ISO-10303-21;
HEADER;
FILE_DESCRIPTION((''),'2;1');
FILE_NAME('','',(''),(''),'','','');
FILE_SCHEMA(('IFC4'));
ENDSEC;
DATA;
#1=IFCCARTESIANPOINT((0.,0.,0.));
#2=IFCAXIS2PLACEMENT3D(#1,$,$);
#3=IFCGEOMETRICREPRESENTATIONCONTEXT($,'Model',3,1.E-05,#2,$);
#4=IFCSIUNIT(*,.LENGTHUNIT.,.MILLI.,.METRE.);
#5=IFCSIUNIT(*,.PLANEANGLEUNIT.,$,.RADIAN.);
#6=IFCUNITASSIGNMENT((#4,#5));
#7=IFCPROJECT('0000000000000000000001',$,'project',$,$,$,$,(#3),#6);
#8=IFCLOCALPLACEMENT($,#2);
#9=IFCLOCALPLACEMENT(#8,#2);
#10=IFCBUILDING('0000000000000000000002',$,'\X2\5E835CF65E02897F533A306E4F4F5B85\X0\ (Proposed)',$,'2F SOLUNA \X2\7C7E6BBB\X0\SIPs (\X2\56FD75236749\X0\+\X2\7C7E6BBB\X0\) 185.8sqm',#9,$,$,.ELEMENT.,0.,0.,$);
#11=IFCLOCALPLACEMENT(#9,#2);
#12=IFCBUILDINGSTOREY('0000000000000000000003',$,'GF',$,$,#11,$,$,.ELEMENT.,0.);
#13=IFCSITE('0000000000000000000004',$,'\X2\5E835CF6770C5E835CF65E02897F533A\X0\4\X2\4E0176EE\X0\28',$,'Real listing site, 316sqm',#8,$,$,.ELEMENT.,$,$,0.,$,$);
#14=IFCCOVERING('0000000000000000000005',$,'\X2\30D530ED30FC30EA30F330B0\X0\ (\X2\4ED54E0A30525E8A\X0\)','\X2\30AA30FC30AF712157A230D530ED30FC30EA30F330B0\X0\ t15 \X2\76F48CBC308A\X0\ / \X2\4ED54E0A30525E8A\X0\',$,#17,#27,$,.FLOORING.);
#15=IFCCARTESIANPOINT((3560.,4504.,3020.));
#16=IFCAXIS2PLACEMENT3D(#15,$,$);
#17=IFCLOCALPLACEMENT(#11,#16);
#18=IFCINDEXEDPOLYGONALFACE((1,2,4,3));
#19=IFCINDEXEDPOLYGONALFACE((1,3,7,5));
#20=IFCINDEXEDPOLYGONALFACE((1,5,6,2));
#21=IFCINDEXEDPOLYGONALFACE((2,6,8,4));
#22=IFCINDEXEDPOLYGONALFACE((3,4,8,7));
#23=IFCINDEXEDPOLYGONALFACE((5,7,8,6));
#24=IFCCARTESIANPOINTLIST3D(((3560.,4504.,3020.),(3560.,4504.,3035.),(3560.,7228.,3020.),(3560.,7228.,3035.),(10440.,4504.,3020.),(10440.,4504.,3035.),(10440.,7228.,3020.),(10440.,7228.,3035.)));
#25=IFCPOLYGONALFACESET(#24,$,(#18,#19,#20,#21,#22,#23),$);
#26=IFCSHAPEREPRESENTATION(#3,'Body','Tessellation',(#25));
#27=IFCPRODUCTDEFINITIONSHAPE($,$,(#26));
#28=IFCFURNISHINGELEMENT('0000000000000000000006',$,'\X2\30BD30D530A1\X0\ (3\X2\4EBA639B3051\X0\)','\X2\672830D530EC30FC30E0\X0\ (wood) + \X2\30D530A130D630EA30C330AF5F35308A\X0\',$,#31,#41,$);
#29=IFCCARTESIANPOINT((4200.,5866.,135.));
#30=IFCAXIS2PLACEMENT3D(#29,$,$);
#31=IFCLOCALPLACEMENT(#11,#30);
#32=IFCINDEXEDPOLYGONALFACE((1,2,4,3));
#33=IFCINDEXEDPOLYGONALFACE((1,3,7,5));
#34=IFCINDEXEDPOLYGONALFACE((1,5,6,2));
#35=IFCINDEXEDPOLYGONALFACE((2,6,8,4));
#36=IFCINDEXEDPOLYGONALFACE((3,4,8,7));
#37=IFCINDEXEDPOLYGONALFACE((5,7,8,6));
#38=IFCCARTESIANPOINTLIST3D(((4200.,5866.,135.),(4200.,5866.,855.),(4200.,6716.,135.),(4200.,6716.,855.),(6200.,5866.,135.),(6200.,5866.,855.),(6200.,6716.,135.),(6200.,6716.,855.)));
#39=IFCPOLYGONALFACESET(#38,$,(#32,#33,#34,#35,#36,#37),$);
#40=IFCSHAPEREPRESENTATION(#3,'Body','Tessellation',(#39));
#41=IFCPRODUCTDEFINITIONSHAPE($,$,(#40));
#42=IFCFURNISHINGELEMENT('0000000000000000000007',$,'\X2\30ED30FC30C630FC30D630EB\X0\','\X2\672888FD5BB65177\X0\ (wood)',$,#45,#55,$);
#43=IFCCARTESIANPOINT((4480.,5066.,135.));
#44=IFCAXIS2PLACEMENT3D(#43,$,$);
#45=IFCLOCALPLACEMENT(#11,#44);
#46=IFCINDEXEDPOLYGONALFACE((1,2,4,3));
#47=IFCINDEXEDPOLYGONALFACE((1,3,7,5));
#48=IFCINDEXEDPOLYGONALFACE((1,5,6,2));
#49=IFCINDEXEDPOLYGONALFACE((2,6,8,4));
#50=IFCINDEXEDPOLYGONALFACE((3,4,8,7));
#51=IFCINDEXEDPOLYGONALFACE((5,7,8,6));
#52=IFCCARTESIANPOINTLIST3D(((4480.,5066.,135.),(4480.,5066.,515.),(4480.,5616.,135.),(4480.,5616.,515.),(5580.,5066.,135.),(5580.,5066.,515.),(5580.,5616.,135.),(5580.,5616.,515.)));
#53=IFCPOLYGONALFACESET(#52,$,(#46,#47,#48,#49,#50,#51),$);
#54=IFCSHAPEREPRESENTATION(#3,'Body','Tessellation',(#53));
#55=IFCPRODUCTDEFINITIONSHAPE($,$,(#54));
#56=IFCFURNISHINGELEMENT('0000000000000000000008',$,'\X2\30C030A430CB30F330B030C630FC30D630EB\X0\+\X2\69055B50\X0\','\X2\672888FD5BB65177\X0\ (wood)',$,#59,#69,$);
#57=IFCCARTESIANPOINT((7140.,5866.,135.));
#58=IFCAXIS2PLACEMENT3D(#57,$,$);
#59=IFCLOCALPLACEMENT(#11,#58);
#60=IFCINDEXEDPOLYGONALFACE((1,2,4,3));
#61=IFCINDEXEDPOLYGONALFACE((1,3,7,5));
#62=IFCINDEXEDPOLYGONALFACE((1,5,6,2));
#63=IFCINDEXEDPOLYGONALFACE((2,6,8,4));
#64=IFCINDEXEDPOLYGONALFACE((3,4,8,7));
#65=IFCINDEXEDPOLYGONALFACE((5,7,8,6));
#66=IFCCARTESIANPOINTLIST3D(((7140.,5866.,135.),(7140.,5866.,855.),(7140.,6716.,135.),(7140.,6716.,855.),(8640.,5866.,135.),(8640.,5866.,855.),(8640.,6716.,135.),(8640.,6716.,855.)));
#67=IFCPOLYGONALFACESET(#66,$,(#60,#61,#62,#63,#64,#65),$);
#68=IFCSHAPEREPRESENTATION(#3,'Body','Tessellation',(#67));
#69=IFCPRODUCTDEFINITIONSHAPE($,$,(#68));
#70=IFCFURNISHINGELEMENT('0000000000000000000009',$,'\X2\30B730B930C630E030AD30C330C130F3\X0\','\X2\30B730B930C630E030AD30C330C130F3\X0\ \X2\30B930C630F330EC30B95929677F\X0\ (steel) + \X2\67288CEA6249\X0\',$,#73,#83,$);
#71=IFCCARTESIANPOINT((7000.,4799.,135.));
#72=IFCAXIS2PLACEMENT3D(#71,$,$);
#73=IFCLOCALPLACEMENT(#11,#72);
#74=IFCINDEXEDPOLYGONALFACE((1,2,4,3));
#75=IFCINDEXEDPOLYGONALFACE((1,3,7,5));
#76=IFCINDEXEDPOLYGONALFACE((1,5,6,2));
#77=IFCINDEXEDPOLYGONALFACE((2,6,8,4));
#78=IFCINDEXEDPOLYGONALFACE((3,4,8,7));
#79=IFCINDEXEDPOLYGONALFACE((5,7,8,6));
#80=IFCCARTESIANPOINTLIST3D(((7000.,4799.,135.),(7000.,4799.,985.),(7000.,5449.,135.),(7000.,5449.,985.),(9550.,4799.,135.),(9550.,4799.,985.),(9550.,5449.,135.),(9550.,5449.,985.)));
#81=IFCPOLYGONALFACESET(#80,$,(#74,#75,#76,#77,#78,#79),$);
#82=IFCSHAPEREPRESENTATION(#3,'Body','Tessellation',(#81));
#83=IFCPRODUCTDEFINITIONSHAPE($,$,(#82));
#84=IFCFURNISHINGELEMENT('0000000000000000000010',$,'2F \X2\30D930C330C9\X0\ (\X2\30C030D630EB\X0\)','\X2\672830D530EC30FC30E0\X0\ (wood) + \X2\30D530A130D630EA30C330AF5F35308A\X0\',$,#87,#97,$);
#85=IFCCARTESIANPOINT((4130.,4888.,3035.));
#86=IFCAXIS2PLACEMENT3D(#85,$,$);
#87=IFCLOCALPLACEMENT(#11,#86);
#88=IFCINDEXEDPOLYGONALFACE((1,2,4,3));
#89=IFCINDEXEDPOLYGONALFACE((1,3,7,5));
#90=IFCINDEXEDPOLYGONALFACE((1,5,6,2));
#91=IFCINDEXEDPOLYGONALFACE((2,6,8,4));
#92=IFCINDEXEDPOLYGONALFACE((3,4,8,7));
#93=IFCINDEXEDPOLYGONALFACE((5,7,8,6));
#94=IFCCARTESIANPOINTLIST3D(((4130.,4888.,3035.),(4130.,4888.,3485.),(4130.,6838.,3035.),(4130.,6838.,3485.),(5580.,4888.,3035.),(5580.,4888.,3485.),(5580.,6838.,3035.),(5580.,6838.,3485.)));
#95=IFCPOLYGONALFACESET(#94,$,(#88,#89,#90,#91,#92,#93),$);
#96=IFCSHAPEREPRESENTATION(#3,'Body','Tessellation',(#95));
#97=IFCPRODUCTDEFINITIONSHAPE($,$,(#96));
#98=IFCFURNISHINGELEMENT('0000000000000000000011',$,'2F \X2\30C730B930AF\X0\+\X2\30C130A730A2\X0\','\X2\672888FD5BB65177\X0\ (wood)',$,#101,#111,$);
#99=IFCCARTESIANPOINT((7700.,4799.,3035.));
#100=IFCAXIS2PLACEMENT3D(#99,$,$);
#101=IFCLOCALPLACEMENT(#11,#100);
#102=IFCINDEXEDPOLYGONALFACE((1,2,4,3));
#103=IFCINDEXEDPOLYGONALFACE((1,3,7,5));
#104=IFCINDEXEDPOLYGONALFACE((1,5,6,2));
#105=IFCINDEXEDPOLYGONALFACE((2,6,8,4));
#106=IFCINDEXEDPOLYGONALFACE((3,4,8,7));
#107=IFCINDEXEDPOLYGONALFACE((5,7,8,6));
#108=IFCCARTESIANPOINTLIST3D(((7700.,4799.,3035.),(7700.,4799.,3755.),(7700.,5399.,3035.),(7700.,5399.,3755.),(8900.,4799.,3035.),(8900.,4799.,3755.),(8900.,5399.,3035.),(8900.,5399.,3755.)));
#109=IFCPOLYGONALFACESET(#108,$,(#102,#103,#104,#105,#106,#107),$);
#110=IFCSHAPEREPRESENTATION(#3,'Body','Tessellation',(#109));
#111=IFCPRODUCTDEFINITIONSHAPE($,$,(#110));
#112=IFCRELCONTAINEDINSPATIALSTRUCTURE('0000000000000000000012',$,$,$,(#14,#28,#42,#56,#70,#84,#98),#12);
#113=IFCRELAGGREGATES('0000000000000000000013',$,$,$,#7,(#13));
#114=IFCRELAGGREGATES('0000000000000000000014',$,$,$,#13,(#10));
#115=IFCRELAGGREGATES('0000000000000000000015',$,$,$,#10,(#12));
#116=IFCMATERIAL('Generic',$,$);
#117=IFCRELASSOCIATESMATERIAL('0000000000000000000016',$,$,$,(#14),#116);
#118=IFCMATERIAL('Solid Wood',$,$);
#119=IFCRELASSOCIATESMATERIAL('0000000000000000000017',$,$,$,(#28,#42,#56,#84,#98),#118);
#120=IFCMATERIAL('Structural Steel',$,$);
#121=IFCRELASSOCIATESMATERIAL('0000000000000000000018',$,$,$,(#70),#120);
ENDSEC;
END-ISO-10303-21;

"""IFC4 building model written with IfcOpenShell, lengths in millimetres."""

from ifc_helpers import new_model, si_unit, frame, frame_2d, origin, place, context, project, spatial, rectangle, extrude, material, element, save


model = new_model("IFC4")

# Units and contexts
model_context = context("Model", 3, precision=1e-05, world=origin())
ifc_project = project(units=[si_unit("LENGTHUNIT", "METRE", prefix="MILLI"), si_unit("PLANEANGLEUNIT", "RADIAN")], contexts=[model_context])

# Site, building, storey
site_placement = place(None, origin())
site = spatial("IfcSite", under=ifc_project, at=site_placement, Name="広島県広島市西区4丁目28", ObjectType="Real listing site, 316sqm", CompositionType="ELEMENT", RefElevation=0.0)
building_placement = place(site_placement, origin())
building = spatial("IfcBuilding", under=site, at=building_placement, Name="広島市西区の住宅 (Proposed)", ObjectType="2F SOLUNA 籾殻SIPs (国産杉+籾殻) 185.8sqm", CompositionType="ELEMENT", ElevationOfRefHeight=0.0, ElevationOfTerrain=0.0)
storey_placement = place(building_placement, origin())
storey = spatial("IfcBuildingStorey", under=building, at=storey_placement, Name="GF", CompositionType="ELEMENT", Elevation=0.0)

# Shared definitions
ifc_material_1 = material(Name="Solid Wood")

# Shared definitions
ifc_material_2 = material(Name="Generic")

# Shared definitions
ifc_material_3 = material(Name="Structural Steel")

# Covering
covering_placement = place(storey_placement, frame((3560.0, 4504.0, 3020.0)))
element("IfcCovering", 1, at=covering_placement, inside=storey, material=ifc_material_2, Name="フローリング (仕上げ床)", Description="オーク無垢フローリング t15 直貼り / 仕上げ床", PredefinedType="FLOORING", context=model_context, shape_type="SweptSolid", body=[
    extrude(rectangle(XDim=6880.0, YDim=2724.0, at=frame_2d((3440.0, 1362.0))), frame((3560.0, 4504.0, 3020.0)), (0.0, 0.0, 1.0), 15.0),
])

# Furnishing elements
furnishing_1_placement = place(storey_placement, frame((4200.0, 5866.0, 135.0)))
element("IfcFurnishingElement", 2, at=furnishing_1_placement, inside=storey, material=ifc_material_1, Name="ソファ (3人掛け)", Description="木フレーム (wood) + ファブリック張り", context=model_context, shape_type="SweptSolid", body=[
    extrude(rectangle(XDim=2000.0, YDim=850.0, at=frame_2d((1000.0, 425.0))), frame((4200.0, 5866.0, 135.0)), (0.0, 0.0, 1.0), 720.0),
])
furnishing_2_placement = place(storey_placement, frame((4480.0, 5066.0, 135.0)))
element("IfcFurnishingElement", 3, at=furnishing_2_placement, inside=storey, material=ifc_material_1, Name="ローテーブル", Description="木製家具 (wood)", context=model_context, shape_type="SweptSolid", body=[
    extrude(rectangle(XDim=1100.0, YDim=550.0, at=frame_2d((550.0, 275.0))), frame((4480.0, 5066.0, 135.0)), (0.0, 0.0, 1.0), 380.0),
])
furnishing_3_placement = place(storey_placement, frame((7140.0, 5866.0, 135.0)))
element("IfcFurnishingElement", 4, at=furnishing_3_placement, inside=storey, material=ifc_material_1, Name="ダイニングテーブル+椅子", Description="木製家具 (wood)", context=model_context, shape_type="SweptSolid", body=[
    extrude(rectangle(XDim=1500.0, YDim=850.0, at=frame_2d((750.0, 425.0))), frame((7140.0, 5866.0, 135.0)), (0.0, 0.0, 1.0), 720.0),
])
furnishing_4_placement = place(storey_placement, frame((7000.0, 4799.0, 135.0)))
element("IfcFurnishingElement", 5, at=furnishing_4_placement, inside=storey, material=ifc_material_3, Name="システムキッチン", Description="システムキッチン ステンレス天板 (steel) + 木質扉", context=model_context, shape_type="SweptSolid", body=[
    extrude(rectangle(XDim=2550.0, YDim=650.0, at=frame_2d((1275.0, 325.0))), frame((7000.0, 4799.0, 135.0)), (0.0, 0.0, 1.0), 850.0),
])
furnishing_5_placement = place(storey_placement, frame((4130.0, 4888.0, 3035.0)))
element("IfcFurnishingElement", 6, at=furnishing_5_placement, inside=storey, material=ifc_material_1, Name="2F ベッド (ダブル)", Description="木フレーム (wood) + ファブリック張り", context=model_context, shape_type="SweptSolid", body=[
    extrude(rectangle(XDim=1450.0, YDim=1950.0, at=frame_2d((725.0, 975.0))), frame((4130.0, 4888.0, 3035.0)), (0.0, 0.0, 1.0), 450.0),
])
furnishing_6_placement = place(storey_placement, frame((7700.0, 4799.0, 3035.0)))
element("IfcFurnishingElement", 7, at=furnishing_6_placement, inside=storey, material=ifc_material_1, Name="2F デスク+チェア", Description="木製家具 (wood)", context=model_context, shape_type="SweptSolid", body=[
    extrude(rectangle(XDim=1200.0, YDim=600.0, at=frame_2d((600.0, 300.0))), frame((7700.0, 4799.0, 3035.0)), (0.0, 0.0, 1.0), 720.0),
])

save(model, "model.ifc")
